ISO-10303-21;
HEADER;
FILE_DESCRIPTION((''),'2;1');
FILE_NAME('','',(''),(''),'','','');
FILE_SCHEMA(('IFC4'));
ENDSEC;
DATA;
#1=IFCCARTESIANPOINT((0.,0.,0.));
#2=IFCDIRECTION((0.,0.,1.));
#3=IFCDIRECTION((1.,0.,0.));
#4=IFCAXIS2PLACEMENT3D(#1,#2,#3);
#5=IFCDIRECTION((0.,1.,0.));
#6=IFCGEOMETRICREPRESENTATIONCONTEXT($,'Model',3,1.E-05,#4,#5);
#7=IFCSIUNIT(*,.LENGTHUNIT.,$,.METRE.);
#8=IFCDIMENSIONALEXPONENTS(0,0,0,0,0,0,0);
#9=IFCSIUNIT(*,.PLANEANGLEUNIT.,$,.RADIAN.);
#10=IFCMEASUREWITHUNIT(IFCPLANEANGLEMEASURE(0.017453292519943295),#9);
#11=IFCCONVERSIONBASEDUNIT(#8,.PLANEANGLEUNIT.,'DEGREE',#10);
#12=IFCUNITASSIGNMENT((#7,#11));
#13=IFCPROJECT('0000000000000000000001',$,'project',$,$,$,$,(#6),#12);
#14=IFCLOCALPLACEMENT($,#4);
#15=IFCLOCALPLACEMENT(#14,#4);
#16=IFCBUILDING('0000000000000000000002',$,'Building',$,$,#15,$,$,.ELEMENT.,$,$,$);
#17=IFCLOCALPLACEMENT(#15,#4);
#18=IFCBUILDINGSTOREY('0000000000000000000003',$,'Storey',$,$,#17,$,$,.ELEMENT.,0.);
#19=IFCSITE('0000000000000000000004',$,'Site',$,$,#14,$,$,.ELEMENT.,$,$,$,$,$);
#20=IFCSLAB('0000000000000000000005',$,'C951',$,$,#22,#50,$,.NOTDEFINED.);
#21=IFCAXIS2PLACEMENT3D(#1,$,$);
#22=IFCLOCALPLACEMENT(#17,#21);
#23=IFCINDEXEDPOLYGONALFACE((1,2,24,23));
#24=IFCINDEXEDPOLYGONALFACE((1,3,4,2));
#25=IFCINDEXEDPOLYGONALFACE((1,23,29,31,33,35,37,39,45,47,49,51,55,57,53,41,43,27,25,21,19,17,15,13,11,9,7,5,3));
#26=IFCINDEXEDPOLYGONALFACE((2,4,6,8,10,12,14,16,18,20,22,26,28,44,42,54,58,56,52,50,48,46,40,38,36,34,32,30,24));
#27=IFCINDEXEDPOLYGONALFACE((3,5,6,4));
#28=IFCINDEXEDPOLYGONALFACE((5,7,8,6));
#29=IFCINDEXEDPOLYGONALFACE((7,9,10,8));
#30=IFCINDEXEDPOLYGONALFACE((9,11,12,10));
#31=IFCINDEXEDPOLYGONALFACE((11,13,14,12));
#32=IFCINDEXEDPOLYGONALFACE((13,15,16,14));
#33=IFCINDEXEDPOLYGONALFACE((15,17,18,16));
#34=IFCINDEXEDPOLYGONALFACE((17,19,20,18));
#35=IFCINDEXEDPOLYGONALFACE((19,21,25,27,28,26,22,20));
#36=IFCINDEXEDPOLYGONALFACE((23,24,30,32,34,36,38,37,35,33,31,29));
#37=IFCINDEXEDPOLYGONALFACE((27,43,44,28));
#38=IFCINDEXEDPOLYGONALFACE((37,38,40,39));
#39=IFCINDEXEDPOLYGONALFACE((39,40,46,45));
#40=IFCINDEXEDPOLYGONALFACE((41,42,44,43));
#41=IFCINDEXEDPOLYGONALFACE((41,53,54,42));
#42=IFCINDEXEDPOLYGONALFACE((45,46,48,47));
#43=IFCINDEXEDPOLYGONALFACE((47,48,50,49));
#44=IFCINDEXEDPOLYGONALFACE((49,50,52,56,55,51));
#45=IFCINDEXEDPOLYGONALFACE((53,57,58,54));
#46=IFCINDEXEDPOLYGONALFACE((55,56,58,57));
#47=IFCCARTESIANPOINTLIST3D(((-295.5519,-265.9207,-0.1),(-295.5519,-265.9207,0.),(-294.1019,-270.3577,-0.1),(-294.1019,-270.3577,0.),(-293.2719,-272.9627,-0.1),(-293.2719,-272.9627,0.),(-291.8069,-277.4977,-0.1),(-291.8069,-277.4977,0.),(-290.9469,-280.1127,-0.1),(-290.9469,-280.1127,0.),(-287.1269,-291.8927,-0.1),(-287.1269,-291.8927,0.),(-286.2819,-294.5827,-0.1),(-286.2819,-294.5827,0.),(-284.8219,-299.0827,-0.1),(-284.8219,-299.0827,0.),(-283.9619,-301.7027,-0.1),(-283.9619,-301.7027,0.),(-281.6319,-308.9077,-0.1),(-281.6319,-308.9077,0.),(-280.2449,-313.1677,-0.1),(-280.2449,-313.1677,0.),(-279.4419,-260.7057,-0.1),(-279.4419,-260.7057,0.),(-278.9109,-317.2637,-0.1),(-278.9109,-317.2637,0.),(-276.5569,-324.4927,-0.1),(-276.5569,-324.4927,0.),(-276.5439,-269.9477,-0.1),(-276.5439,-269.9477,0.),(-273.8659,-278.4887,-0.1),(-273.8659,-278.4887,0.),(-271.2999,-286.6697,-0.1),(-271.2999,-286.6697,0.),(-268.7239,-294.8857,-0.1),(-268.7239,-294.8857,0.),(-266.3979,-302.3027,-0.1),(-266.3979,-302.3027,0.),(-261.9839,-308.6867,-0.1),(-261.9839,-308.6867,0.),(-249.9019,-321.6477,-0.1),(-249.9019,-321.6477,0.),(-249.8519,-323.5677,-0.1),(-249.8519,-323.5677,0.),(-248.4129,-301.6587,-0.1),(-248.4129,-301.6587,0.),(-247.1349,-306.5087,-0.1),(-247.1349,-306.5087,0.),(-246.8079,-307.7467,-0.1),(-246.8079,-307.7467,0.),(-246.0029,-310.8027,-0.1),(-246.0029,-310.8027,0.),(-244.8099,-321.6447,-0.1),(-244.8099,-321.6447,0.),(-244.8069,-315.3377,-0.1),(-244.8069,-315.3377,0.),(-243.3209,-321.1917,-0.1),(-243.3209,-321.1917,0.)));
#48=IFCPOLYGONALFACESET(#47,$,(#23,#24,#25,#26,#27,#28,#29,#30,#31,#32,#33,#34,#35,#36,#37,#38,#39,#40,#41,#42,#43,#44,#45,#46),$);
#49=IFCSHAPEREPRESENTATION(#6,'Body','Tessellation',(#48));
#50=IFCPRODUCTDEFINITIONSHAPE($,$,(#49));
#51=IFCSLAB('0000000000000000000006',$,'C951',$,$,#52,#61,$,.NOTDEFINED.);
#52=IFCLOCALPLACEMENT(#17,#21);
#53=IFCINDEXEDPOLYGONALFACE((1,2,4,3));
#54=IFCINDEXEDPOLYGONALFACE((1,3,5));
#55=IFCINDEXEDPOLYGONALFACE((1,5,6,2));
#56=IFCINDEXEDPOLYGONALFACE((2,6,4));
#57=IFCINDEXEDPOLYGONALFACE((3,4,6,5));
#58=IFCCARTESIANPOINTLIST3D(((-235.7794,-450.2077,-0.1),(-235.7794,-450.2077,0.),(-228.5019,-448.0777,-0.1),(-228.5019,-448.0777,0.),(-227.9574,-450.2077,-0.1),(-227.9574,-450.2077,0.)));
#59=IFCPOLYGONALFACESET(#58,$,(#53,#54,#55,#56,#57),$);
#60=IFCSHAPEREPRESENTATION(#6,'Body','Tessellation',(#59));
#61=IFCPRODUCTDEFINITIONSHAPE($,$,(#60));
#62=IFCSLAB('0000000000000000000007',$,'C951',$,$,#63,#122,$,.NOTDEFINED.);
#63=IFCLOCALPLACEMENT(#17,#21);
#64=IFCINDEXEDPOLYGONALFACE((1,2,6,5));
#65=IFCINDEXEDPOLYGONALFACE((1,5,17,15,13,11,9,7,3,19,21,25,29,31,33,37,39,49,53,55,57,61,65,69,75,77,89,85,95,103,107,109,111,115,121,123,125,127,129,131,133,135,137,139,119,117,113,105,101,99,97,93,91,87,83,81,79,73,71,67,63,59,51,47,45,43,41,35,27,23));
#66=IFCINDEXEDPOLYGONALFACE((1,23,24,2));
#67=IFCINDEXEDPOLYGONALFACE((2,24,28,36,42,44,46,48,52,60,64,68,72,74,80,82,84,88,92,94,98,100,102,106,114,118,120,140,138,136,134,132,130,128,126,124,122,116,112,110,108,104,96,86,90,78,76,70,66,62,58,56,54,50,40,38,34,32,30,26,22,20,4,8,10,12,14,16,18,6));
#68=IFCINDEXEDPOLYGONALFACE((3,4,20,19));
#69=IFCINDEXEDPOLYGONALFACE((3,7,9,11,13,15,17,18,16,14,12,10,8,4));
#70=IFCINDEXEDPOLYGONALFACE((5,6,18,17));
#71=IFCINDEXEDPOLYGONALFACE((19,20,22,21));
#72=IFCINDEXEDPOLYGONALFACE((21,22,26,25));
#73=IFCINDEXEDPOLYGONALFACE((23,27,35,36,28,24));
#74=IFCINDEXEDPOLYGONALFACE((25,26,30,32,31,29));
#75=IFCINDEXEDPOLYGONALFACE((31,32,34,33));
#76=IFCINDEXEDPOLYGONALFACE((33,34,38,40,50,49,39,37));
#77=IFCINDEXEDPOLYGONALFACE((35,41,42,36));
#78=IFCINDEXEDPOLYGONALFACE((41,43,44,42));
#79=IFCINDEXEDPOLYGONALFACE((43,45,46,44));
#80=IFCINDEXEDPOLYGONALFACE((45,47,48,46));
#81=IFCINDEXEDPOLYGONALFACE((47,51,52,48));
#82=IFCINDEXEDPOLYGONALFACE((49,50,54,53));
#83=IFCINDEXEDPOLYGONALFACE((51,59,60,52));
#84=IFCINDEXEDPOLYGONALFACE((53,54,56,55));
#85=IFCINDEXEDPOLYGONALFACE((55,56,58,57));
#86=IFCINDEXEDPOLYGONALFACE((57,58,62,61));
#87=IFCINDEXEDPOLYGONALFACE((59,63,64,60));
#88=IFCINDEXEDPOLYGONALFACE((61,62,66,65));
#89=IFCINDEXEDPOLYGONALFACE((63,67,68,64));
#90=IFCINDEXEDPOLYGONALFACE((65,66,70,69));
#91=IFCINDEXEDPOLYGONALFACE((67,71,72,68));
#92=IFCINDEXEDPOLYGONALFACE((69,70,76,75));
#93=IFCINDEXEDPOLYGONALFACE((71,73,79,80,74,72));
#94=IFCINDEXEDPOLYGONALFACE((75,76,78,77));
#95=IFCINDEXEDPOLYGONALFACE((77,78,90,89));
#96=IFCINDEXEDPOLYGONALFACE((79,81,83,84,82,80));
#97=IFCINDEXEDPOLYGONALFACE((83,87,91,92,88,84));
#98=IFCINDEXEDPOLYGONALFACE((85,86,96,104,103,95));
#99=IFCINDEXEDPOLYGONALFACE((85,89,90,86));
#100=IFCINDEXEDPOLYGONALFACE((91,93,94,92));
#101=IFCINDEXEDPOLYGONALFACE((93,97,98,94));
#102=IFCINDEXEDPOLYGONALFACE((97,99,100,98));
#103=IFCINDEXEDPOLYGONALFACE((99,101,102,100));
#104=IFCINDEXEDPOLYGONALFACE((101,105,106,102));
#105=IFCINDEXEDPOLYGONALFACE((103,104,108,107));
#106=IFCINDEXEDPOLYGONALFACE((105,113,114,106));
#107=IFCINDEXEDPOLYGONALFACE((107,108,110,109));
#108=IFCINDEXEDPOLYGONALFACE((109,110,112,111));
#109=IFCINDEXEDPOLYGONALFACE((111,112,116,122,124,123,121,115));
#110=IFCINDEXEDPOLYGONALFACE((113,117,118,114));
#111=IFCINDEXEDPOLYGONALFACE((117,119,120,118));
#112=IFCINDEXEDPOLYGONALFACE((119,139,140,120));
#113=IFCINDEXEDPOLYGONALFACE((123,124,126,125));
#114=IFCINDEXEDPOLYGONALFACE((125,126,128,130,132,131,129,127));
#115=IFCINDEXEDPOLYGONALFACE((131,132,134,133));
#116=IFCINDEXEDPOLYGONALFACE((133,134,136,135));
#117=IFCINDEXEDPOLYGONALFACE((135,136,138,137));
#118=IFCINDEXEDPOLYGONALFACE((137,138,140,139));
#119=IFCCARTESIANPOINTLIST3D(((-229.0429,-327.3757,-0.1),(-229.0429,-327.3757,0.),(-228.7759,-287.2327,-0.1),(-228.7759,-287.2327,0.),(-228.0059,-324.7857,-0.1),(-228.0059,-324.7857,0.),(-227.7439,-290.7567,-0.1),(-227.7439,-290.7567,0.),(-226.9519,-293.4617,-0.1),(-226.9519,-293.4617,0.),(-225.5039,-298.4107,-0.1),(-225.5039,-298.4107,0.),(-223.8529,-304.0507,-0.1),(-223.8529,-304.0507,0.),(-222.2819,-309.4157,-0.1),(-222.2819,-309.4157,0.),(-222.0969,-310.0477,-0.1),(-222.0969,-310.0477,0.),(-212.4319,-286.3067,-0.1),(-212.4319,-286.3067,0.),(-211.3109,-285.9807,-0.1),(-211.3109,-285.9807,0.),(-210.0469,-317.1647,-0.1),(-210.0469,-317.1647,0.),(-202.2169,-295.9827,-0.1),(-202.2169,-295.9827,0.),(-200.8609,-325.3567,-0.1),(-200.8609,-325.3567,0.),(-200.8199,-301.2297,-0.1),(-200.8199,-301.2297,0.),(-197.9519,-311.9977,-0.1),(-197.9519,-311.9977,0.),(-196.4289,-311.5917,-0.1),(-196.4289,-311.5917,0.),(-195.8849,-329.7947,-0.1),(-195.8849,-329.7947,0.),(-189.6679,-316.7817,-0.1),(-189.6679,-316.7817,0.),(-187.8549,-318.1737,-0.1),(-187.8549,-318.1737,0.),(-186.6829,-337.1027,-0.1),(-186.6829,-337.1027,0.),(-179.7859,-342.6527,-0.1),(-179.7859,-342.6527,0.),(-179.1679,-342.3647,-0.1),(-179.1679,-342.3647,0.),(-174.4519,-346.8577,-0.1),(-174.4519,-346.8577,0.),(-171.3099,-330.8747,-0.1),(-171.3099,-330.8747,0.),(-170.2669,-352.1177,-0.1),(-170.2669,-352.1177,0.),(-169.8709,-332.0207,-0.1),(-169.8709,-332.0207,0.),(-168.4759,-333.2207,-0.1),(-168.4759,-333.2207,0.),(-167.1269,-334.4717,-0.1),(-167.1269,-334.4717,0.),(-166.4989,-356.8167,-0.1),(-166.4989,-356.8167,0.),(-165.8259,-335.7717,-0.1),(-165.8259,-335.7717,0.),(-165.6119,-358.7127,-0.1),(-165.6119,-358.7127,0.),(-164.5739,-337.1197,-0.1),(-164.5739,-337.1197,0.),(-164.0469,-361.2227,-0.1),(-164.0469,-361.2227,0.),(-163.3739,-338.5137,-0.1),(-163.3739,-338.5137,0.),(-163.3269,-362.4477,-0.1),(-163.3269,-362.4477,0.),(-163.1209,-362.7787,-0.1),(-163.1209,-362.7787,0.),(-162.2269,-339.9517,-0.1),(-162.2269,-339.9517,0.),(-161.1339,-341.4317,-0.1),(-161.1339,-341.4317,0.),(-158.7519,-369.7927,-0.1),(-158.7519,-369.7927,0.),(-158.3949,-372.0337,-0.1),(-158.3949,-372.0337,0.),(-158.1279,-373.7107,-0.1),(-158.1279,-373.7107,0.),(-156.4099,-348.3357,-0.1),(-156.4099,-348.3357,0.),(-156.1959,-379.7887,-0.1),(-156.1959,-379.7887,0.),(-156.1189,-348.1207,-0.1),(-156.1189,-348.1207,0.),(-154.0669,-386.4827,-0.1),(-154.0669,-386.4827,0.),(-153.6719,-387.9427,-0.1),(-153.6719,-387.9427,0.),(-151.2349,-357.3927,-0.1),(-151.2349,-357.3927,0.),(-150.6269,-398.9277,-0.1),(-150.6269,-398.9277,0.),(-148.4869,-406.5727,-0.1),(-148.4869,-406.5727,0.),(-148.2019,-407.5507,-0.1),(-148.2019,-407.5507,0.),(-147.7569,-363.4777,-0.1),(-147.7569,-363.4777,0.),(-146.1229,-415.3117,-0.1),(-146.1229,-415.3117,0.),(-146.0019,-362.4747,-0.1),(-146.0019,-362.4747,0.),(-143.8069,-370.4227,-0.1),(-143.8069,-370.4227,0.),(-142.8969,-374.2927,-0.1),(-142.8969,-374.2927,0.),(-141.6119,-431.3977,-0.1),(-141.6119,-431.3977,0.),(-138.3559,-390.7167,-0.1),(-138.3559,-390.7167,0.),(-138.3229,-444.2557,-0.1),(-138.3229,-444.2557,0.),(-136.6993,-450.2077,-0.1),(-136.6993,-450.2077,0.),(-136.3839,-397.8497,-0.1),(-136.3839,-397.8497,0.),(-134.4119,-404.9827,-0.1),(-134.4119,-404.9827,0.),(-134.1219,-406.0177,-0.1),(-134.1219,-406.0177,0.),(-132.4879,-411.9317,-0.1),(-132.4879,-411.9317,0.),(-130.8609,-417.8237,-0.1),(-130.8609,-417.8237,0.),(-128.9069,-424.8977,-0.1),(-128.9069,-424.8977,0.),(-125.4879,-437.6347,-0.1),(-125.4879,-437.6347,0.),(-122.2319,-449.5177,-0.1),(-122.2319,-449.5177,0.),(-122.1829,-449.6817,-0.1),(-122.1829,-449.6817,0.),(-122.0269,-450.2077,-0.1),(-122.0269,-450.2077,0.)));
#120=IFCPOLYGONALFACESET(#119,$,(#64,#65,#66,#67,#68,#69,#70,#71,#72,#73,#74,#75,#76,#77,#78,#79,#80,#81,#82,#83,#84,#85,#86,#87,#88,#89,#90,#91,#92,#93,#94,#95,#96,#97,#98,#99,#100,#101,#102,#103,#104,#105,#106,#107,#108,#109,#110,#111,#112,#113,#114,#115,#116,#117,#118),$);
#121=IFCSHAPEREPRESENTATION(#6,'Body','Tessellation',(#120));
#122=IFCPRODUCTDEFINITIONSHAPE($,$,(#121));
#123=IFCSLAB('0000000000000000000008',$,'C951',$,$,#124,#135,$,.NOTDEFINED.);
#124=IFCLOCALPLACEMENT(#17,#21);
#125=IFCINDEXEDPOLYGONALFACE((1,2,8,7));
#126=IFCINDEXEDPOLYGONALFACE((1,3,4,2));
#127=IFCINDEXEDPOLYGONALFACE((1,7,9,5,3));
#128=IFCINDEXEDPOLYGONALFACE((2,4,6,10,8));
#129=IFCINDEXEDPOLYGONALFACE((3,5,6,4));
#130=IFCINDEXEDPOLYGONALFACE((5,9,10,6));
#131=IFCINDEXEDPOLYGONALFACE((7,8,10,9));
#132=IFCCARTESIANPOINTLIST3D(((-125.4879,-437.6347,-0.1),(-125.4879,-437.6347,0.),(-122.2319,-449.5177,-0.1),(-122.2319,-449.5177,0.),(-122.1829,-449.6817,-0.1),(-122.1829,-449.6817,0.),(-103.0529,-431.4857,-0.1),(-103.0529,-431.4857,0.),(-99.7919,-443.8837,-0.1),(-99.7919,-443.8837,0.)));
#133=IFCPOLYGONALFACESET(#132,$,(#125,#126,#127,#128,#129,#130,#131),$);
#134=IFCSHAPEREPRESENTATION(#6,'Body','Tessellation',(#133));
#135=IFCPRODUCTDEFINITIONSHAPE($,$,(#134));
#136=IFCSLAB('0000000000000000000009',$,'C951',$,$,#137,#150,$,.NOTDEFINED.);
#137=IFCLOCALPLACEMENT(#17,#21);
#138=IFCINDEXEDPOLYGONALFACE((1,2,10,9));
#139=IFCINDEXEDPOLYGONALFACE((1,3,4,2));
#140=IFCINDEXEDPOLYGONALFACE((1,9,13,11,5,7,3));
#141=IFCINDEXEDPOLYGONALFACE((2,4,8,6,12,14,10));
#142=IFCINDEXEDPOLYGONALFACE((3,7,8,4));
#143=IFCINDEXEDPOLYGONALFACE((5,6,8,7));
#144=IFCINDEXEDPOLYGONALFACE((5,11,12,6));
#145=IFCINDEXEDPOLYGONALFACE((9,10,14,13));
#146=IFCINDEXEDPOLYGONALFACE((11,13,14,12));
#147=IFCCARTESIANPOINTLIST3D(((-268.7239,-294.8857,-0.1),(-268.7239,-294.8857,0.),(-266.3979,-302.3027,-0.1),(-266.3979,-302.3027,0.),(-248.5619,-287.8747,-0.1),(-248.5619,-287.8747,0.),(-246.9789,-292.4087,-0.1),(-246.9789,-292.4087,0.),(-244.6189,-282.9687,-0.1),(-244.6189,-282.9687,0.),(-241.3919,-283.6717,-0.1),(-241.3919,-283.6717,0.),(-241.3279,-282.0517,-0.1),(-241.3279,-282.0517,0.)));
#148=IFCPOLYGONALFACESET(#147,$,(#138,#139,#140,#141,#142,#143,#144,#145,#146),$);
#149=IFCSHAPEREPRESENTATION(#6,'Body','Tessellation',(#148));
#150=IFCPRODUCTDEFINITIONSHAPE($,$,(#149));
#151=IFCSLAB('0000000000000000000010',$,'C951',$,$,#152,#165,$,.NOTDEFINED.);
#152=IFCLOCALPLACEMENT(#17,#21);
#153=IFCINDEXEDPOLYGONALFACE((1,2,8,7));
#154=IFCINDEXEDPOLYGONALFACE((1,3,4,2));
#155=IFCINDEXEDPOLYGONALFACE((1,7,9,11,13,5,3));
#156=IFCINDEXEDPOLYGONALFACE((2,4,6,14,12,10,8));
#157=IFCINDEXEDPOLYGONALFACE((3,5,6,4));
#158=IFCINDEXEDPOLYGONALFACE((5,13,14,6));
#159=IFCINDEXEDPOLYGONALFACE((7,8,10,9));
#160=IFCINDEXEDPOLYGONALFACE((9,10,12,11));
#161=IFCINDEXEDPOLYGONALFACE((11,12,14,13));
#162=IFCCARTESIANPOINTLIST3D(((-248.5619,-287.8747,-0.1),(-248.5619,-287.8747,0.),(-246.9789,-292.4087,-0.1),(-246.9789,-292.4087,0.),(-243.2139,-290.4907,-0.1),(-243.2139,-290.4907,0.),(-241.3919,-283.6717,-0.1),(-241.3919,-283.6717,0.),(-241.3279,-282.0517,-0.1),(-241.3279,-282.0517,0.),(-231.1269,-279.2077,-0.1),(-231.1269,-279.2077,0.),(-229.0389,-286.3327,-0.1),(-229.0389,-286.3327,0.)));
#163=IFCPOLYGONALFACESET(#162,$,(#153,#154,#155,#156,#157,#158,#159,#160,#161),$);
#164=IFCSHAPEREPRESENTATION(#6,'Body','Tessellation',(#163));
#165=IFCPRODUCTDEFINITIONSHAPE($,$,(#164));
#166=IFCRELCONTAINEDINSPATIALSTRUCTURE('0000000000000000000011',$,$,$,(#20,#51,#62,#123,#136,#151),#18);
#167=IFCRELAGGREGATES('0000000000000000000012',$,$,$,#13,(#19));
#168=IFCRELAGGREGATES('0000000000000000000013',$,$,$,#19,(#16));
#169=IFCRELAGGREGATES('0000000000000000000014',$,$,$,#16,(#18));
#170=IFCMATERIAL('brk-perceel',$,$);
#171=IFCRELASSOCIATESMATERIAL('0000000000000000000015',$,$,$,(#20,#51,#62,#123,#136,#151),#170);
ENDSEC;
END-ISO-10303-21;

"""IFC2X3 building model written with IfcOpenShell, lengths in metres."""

from ifc_helpers import new_model, entity, si_unit, converted_unit, direction, frame, origin_with_axes, place, context, project, spatial, polyline, outline, extrude, material, element, save


model = new_model("IFC2X3")

# Units and contexts
model_context = context("Model", 3, precision=1e-05, world=origin_with_axes(), true_north=direction((0.0, 1.0, 0.0)))
ifc_project = project(units=[si_unit("LENGTHUNIT", "METRE"), converted_unit("PLANEANGLEUNIT", "DEGREE", entity("IfcPlaneAngleMeasure", 0.017453292519943295), si_unit("PLANEANGLEUNIT", "RADIAN"), dimensions=[0, 0, 0, 0, 0, 0, 0])], contexts=[model_context])

# Site, building, storey
site_placement = place(None, origin_with_axes())
site = spatial("IfcSite", under=ifc_project, at=site_placement, Name="Site", CompositionType="ELEMENT")
building_placement = place(site_placement, origin_with_axes())
building = spatial("IfcBuilding", under=site, at=building_placement, Name="Building", CompositionType="ELEMENT")
storey_placement = place(building_placement, origin_with_axes())
storey = spatial("IfcBuildingStorey", under=building, at=storey_placement, Name="Storey", CompositionType="ELEMENT", Elevation=0.0)

# Slabs
ifc_material = material(Name="brk-perceel")
slab_1_placement = place(storey_placement, frame((0.0, 0.0, -0.1), z_axis=(0.0, 0.0, 1.0), x_axis=(1.0, 0.0, 0.0)))
element("IfcSlab", 1, at=slab_1_placement, inside=storey, material=ifc_material, Name="C951", PredefinedType="NOTDEFINED", context=model_context, shape_type="SweptSolid", body=[
    extrude(outline(polyline([(-278.9109, -317.2637), (-280.2449, -313.1677), (-281.6319, -308.9077), (-283.9619, -301.7027), (-284.8219, -299.0827), (-286.2819, -294.5827), (-287.1269, -291.8927), (-290.9469, -280.1127), (-291.8069, -277.4977), (-293.2719, -272.9627), (-294.1019, -270.3577), (-295.5519, -265.9207), (-279.4419, -260.7057), (-276.5439, -269.9477), (-273.8659, -278.4887), (-271.2999, -286.6697), (-268.7239, -294.8857), (-266.3979, -302.3027), (-261.9839, -308.6867), (-248.4129, -301.6587), (-247.1349, -306.5087), (-246.8079, -307.7467), (-246.0029, -310.8027), (-244.8069, -315.3377), (-243.3209, -321.1917), (-244.8099, -321.6447), (-249.9019, -321.6477), (-249.8519, -323.5677), (-276.5569, -324.4927), (-278.9109, -317.2637)])), origin_with_axes(), (0.0, 0.0, 1.0), 0.1),
])
slab_2_placement = place(storey_placement, frame((0.0, 0.0, -0.1), z_axis=(0.0, 0.0, 1.0), x_axis=(1.0, 0.0, 0.0)))
element("IfcSlab", 2, at=slab_2_placement, inside=storey, material=ifc_material, Name="C951", PredefinedType="NOTDEFINED", context=model_context, shape_type="SweptSolid", body=[
    extrude(outline(polyline([(-228.5019, -448.0777), (-227.9574, -450.2077), (-235.7794, -450.2077), (-228.5019, -448.0777)])), origin_with_axes(), (0.0, 0.0, 1.0), 0.1),
])
slab_3_placement = place(storey_placement, frame((0.0, 0.0, -0.1), z_axis=(0.0, 0.0, 1.0), x_axis=(1.0, 0.0, 0.0)))
element("IfcSlab", 3, at=slab_3_placement, inside=storey, material=ifc_material, Name="C951", PredefinedType="NOTDEFINED", context=model_context, shape_type="SweptSolid", body=[
    extrude(outline(polyline([(-138.3229, -444.2557), (-141.6119, -431.3977), (-146.1229, -415.3117), (-148.2019, -407.5507), (-148.4869, -406.5727), (-150.6269, -398.9277), (-153.6719, -387.9427), (-154.0669, -386.4827), (-156.1959, -379.7887), (-158.1279, -373.7107), (-158.3949, -372.0337), (-158.7519, -369.7927), (-163.1209, -362.7787), (-163.3269, -362.4477), (-164.0469, -361.2227), (-165.6119, -358.7127), (-166.4989, -356.8167), (-170.2669, -352.1177), (-174.4519, -346.8577), (-179.1679, -342.3647), (-179.7859, -342.6527), (-186.6829, -337.1027), (-195.8849, -329.7947), (-200.8609, -325.3567), (-210.0469, -317.1647), (-229.0429, -327.3757), (-228.0059, -324.7857), (-222.0969, -310.0477), (-222.2819, -309.4157), (-223.8529, -304.0507), (-225.5039, -298.4107), (-226.9519, -293.4617), (-227.7439, -290.7567), (-228.7759, -287.2327), (-212.4319, -286.3067), (-211.3109, -285.9807), (-202.2169, -295.9827), (-200.8199, -301.2297), (-197.9519, -311.9977), (-196.4289, -311.5917), (-189.6679, -316.7817), (-187.8549, -318.1737), (-171.3099, -330.8747), (-169.8709, -332.0207), (-168.4759, -333.2207), (-167.1269, -334.4717), (-165.8259, -335.7717), (-164.5739, -337.1197), (-163.3739, -338.5137), (-162.2269, -339.9517), (-161.1339, -341.4317), (-156.1189, -348.1207), (-156.4099, -348.3357), (-151.2349, -357.3927), (-147.7569, -363.4777), (-146.0019, -362.4747), (-143.8069, -370.4227), (-142.8969, -374.2927), (-138.3559, -390.7167), (-136.3839, -397.8497), (-134.4119, -404.9827), (-134.1219, -406.0177), (-132.4879, -411.9317), (-130.8609, -417.8237), (-128.9069, -424.8977), (-125.4879, -437.6347), (-122.2319, -449.5177), (-122.1829, -449.6817), (-122.0269, -450.2077), (-136.6993, -450.2077), (-138.3229, -444.2557)])), origin_with_axes(), (0.0, 0.0, 1.0), 0.1),
])
slab_4_placement = place(storey_placement, frame((0.0, 0.0, -0.1), z_axis=(0.0, 0.0, 1.0), x_axis=(1.0, 0.0, 0.0)))
element("IfcSlab", 4, at=slab_4_placement, inside=storey, material=ifc_material, Name="C951", PredefinedType="NOTDEFINED", context=model_context, shape_type="SweptSolid", body=[
    extrude(outline(polyline([(-122.2319, -449.5177), (-125.4879, -437.6347), (-103.0529, -431.4857), (-99.7919, -443.8837), (-122.1829, -449.6817), (-122.2319, -449.5177)])), origin_with_axes(), (0.0, 0.0, 1.0), 0.1),
])
slab_5_placement = place(storey_placement, frame((0.0, 0.0, -0.1), z_axis=(0.0, 0.0, 1.0), x_axis=(1.0, 0.0, 0.0)))
element("IfcSlab", 5, at=slab_5_placement, inside=storey, material=ifc_material, Name="C951", PredefinedType="NOTDEFINED", context=model_context, shape_type="SweptSolid", body=[
    extrude(outline(polyline([(-241.3919, -283.6717), (-248.5619, -287.8747), (-246.9789, -292.4087), (-266.3979, -302.3027), (-268.7239, -294.8857), (-244.6189, -282.9687), (-241.3279, -282.0517), (-241.3919, -283.6717)])), origin_with_axes(), (0.0, 0.0, 1.0), 0.1),
])
slab_6_placement = place(storey_placement, frame((0.0, 0.0, -0.1), z_axis=(0.0, 0.0, 1.0), x_axis=(1.0, 0.0, 0.0)))
element("IfcSlab", 6, at=slab_6_placement, inside=storey, material=ifc_material, Name="C951", PredefinedType="NOTDEFINED", context=model_context, shape_type="SweptSolid", body=[
    extrude(outline(polyline([(-248.5619, -287.8747), (-241.3919, -283.6717), (-241.3279, -282.0517), (-231.1269, -279.2077), (-229.0389, -286.3327), (-243.2139, -290.4907), (-246.9789, -292.4087), (-248.5619, -287.8747)])), origin_with_axes(), (0.0, 0.0, 1.0), 0.1),
])

save(model, "model.ifc")
